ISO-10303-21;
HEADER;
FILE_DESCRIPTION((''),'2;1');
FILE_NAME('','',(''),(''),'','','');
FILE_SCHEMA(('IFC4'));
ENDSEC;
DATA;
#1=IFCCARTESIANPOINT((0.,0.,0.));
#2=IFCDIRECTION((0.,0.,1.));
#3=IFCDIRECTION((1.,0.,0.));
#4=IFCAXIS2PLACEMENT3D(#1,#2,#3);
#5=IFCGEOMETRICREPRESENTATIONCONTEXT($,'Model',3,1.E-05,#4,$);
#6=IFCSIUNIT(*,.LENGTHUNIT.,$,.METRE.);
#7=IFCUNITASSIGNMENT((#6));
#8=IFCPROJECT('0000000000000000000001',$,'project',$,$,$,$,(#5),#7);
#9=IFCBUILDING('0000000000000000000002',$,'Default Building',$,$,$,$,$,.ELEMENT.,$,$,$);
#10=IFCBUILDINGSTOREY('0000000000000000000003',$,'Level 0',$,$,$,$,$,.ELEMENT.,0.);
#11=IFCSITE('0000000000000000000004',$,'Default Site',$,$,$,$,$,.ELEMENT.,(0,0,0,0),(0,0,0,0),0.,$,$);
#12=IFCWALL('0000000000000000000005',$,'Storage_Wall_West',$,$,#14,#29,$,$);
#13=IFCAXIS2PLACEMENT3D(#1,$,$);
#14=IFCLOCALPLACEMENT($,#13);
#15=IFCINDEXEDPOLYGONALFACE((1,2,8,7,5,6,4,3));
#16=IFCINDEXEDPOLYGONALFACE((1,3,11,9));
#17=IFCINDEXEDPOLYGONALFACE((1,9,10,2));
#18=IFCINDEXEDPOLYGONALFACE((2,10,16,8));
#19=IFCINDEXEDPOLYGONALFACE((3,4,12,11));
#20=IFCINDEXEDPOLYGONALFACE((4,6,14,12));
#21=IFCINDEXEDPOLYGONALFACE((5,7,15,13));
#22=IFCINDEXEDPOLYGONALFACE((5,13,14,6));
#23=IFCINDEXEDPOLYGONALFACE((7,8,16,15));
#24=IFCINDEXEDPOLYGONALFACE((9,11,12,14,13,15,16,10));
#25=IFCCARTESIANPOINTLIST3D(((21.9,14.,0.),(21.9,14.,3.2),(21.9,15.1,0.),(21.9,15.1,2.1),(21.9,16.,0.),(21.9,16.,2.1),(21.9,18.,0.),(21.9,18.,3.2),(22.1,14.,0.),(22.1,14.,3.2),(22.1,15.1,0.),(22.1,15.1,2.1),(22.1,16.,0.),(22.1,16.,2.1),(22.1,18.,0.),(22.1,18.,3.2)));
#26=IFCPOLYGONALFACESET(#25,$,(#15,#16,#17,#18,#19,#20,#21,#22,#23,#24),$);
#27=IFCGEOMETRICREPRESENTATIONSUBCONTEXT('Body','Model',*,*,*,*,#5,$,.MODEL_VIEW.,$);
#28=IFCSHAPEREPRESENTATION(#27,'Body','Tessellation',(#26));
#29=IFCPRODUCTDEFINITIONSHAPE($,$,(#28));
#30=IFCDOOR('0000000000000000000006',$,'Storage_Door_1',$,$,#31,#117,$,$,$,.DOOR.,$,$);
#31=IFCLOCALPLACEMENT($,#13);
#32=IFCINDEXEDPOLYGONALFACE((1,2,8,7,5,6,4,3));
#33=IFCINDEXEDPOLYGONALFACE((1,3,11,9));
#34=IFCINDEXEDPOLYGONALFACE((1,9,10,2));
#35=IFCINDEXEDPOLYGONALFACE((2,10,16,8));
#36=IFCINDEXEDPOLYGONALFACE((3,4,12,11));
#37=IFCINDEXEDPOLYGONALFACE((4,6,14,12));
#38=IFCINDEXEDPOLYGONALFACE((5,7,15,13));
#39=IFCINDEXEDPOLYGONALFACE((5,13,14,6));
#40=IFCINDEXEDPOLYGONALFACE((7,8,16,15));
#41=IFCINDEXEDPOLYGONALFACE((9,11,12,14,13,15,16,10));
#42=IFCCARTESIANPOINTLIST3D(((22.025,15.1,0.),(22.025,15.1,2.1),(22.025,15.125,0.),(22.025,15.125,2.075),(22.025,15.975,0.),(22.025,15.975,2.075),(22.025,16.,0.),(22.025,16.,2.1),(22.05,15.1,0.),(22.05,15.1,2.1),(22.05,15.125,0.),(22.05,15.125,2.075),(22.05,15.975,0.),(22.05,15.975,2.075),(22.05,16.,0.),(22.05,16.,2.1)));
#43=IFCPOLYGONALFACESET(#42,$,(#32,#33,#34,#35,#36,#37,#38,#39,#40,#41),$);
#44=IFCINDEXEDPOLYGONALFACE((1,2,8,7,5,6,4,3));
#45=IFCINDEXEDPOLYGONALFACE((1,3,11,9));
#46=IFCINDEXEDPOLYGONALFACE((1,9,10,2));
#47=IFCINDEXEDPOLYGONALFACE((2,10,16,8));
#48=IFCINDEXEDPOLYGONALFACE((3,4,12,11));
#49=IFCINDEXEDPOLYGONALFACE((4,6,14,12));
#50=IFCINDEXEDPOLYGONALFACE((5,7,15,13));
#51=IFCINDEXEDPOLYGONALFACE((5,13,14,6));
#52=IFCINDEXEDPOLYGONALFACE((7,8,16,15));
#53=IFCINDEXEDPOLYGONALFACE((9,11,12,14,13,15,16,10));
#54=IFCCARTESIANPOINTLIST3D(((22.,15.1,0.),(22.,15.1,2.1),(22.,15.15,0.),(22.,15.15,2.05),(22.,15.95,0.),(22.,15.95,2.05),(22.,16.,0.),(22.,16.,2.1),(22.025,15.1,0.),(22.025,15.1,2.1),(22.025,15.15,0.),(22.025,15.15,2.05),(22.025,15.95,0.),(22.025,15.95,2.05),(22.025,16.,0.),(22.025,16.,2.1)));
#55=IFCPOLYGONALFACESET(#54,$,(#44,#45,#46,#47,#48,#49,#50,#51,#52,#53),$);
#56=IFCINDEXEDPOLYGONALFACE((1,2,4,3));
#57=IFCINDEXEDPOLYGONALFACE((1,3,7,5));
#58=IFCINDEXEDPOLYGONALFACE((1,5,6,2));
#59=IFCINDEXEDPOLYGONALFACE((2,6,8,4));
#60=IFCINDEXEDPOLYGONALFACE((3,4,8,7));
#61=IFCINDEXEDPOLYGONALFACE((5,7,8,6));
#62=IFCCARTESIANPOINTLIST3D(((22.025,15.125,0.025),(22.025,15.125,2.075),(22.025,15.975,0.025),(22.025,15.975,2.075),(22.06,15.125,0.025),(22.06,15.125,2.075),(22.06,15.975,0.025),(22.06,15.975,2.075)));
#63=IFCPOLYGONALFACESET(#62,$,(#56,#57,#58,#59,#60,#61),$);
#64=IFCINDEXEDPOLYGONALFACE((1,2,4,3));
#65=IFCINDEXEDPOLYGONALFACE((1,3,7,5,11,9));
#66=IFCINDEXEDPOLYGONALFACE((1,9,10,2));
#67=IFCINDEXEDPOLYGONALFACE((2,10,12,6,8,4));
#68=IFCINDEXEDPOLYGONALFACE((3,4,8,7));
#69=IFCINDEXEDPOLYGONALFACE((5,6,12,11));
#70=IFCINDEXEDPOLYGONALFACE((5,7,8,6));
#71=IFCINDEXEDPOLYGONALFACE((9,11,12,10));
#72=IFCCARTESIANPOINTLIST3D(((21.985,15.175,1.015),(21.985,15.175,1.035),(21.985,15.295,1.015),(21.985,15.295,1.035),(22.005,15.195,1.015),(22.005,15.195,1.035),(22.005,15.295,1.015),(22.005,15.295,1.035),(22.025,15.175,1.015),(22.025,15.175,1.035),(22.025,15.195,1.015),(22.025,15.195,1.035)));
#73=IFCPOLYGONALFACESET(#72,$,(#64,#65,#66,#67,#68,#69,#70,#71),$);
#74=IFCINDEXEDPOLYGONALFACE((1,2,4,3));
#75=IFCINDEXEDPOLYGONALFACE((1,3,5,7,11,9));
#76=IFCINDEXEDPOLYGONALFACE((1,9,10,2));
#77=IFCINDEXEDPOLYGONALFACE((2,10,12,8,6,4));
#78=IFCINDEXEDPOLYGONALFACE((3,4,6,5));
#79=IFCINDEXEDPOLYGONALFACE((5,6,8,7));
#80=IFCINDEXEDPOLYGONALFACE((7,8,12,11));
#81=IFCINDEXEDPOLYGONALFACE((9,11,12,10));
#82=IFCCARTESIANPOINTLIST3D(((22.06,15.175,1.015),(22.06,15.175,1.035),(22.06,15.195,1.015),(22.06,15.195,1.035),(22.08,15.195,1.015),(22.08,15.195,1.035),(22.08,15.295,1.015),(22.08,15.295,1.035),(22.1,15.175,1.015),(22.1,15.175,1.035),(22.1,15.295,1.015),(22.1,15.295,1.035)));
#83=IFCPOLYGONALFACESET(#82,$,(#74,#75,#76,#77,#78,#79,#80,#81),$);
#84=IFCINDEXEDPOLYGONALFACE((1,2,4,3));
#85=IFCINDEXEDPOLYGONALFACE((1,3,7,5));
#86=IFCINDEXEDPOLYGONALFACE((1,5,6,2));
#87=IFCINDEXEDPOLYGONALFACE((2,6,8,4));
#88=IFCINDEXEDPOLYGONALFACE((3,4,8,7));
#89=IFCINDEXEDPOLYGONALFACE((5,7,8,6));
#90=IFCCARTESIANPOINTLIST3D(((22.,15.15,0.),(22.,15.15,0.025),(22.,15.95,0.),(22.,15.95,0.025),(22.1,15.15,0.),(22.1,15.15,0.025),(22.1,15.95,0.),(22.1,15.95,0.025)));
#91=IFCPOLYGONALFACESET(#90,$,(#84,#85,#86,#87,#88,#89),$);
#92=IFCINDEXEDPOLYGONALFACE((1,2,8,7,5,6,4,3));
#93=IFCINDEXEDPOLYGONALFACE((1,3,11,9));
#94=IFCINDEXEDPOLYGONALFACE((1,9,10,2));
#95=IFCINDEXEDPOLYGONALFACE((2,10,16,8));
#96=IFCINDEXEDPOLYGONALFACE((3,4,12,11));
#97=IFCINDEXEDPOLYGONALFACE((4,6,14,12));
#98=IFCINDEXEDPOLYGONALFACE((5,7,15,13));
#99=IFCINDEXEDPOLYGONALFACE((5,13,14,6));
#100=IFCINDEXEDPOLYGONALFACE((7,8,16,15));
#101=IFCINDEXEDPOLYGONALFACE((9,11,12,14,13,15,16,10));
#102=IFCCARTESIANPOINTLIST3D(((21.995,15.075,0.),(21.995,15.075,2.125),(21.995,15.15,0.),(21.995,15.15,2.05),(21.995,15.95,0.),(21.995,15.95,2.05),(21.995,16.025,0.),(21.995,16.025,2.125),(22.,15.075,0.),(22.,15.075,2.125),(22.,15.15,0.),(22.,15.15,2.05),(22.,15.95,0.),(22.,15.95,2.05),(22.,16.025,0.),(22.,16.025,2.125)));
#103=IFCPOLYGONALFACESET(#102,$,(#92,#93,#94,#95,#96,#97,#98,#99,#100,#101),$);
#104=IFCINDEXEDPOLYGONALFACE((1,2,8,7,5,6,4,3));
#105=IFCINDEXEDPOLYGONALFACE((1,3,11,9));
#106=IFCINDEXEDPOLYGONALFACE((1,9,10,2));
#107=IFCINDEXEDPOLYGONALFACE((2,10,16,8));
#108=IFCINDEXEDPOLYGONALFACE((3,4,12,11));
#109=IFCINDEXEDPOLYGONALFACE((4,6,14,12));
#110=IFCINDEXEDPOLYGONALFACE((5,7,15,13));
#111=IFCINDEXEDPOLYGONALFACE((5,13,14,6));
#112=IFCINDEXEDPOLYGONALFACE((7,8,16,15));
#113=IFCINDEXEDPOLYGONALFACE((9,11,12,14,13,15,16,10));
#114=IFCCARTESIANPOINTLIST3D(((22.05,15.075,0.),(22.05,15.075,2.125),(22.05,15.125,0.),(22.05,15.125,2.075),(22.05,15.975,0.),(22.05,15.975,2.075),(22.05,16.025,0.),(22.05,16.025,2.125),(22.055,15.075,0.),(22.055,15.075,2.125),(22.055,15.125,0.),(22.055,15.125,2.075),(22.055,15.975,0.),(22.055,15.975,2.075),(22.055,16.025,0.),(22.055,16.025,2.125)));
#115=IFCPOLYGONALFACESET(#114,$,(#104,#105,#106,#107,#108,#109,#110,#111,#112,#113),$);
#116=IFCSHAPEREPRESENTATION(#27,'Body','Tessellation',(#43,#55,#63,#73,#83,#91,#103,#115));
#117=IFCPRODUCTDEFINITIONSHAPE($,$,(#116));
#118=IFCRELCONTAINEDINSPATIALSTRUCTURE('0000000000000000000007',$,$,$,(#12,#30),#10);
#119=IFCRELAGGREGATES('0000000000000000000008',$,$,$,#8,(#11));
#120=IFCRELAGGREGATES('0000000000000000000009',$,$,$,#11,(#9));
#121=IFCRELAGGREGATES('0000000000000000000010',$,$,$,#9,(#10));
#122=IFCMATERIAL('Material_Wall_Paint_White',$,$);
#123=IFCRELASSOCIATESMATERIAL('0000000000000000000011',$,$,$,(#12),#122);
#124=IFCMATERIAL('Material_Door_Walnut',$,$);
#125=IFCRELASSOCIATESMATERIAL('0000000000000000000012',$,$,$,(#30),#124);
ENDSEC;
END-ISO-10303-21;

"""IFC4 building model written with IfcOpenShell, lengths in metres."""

from ifc_helpers import new_model, si_unit, frame, origin_with_axes, place, context, subcontext, project, spatial, line, indexed_curve, outline, extrude, material, element, fill, save


model = new_model("IFC4")

# Units and contexts
model_context = context("Model", 3, precision=1e-05, world=origin_with_axes())
body_context = subcontext(model_context, "Body", "Model", "MODEL_VIEW")
ifc_project = project(units=[si_unit("LENGTHUNIT", "METRE")], contexts=[model_context])

# Site, building, storey
site = spatial("IfcSite", under=ifc_project, Name="Default Site", CompositionType="ELEMENT", RefLatitude=(0, 0, 0, 0), RefLongitude=(0, 0, 0, 0), RefElevation=0.0)
building = spatial("IfcBuilding", under=site, Name="Default Building", CompositionType="ELEMENT")
storey = spatial("IfcBuildingStorey", under=building, Name="Level 0", CompositionType="ELEMENT", Elevation=0.0)

# Shared definitions
ifc_material_1 = material(Name="Material_Wall_Paint_White")

# Shared definitions
ifc_material_2 = material(Name="Material_Door_Walnut")

# Wall, opening, door
wall_1_placement = place(None, frame((22.0, 18.0, 0.0), z_axis=(0.0, 0.0, 1.0), x_axis=(0.0, -1.0, 0.0)))
wall_1 = element("IfcWall", 1, at=wall_1_placement, inside=storey, material=ifc_material_1, Name="Storage_Wall_West", context=body_context, shape_type="SweptSolid", body=[
    extrude(outline(indexed_curve([(0.0, 0.0), (0.0, 0.2), (4.0, 0.2), (4.0, 0.0), (0.0, 0.0)], self_intersect=False)), frame((0.0, -0.1, 0.0), z_axis=(0.0, 0.0, 1.0), x_axis=(1.0, 0.0, 0.0)), (0.0, 0.0, 1.0), 3.2),
])
opening_1_placement = place(wall_1_placement, frame((2.0, -0.5, 0.0), z_axis=(0.0, 0.0, 1.0), x_axis=(1.0, 0.0, 0.0)))
opening_1 = element("IfcOpeningElement", 2, at=opening_1_placement, inside=storey, cuts=wall_1, PredefinedType="OPENING", context=body_context, shape_type="SweptSolid", body=[
    extrude(outline(indexed_curve([(0.0, 0.0), (0.0, 1.0), (0.9, 1.0), (0.9, 0.0), (0.0, 0.0)], self_intersect=False)), origin_with_axes(), (0.0, 0.0, 1.0), 2.1),
])
door_1_placement = place(None, frame((22.0, 16.0, 0.0), z_axis=(0.0, 0.0, 1.0), x_axis=(0.0, -1.0, 0.0)))
door_1 = element("IfcDoor", 3, at=door_1_placement, inside=storey, material=ifc_material_2, Name="Storage_Door_1", PredefinedType="DOOR", context=body_context, shape_type="SweptSolid", body=[
    extrude(outline(indexed_curve([(0.0, 0.0), (0.0, 2.1), (0.9, 2.1), (0.9, 0.0), (0.875, 0.0), (0.875, 2.075), (0.025, 2.075), (0.025, 0.0)], segments=[line(1, 2, 3, 4, 5, 6, 7, 8, 1)])), frame((0.0, 0.025, 0.0), z_axis=(0.0, -1.0, 0.0), x_axis=(1.0, 0.0, 0.0)), (0.0, 0.0, -1.0), 0.025),
    extrude(outline(indexed_curve([(0.0, 0.0), (0.0, 2.1), (0.9, 2.1), (0.9, 0.0), (0.85, 0.0), (0.85, 2.05), (0.05, 2.05), (0.05, 0.0)], segments=[line(1, 2, 3, 4, 5, 6, 7, 8, 1)])), frame((0.0, 0.0, 0.0), z_axis=(0.0, -1.0, 0.0), x_axis=(1.0, 0.0, 0.0)), (0.0, 0.0, -1.0), 0.025),
    extrude(outline(indexed_curve([(0.0, 0.0), (0.85, 0.0), (0.85, 0.035), (0.0, 0.035)], segments=[line(1, 2, 3, 4, 1)])), frame((0.025, 0.025, 0.025), z_axis=(0.0, 0.0, 1.0), x_axis=(1.0, 0.0, 0.0)), (0.0, 0.0, 1.0), 2.05),
    extrude(outline(indexed_curve([(0.0, 0.0), (0.0, -0.04), (-0.12, -0.04), (-0.12, -0.02), (-0.02, -0.02), (-0.02, 0.0)], segments=[line(1, 2, 3, 4, 5, 6, 1)])), frame((0.825, 0.025, 1.015), z_axis=(0.0, 0.0, 1.0), x_axis=(1.0, 0.0, 0.0)), (0.0, 0.0, 1.0), 0.02),
    extrude(outline(indexed_curve([(0.0, 0.0), (0.0, 0.04), (-0.12, 0.04), (-0.12, 0.02), (-0.02, 0.02), (-0.02, 0.0)], segments=[line(1, 2, 3, 4, 5, 6, 1)])), frame((0.825, 0.06, 1.015), z_axis=(0.0, 0.0, 1.0), x_axis=(1.0, 0.0, 0.0)), (0.0, 0.0, 1.0), 0.02),
    extrude(outline(indexed_curve([(0.0, 0.0), (0.8, 0.0), (0.8, 0.1), (0.0, 0.1)], segments=[line(1, 2, 3, 4, 1)])), frame((0.05, 0.0, 0.0), z_axis=(0.0, 0.0, 1.0), x_axis=(1.0, 0.0, 0.0)), (0.0, 0.0, 1.0), 0.025),
    extrude(outline(indexed_curve([(0.0, 0.0), (0.0, 2.125), (0.95, 2.125), (0.95, 0.0), (0.875, 0.0), (0.875, 2.05), (0.075, 2.05), (0.075, 0.0)], segments=[line(1, 2, 3, 4, 5, 6, 7, 8, 1)])), frame((-0.025, -0.005, 0.0), z_axis=(0.0, -1.0, 0.0), x_axis=(1.0, 0.0, 0.0)), (0.0, 0.0, -1.0), 0.005),
    extrude(outline(indexed_curve([(0.0, 0.0), (0.0, 2.125), (0.95, 2.125), (0.95, 0.0), (0.9, 0.0), (0.9, 2.075), (0.05, 2.075), (0.05, 0.0)], segments=[line(1, 2, 3, 4, 5, 6, 7, 8, 1)])), frame((-0.025, 0.05, 0.0), z_axis=(0.0, -1.0, 0.0), x_axis=(1.0, 0.0, 0.0)), (0.0, 0.0, -1.0), 0.005),
])
fill(opening_1, door_1)

save(model, "model.ifc")
